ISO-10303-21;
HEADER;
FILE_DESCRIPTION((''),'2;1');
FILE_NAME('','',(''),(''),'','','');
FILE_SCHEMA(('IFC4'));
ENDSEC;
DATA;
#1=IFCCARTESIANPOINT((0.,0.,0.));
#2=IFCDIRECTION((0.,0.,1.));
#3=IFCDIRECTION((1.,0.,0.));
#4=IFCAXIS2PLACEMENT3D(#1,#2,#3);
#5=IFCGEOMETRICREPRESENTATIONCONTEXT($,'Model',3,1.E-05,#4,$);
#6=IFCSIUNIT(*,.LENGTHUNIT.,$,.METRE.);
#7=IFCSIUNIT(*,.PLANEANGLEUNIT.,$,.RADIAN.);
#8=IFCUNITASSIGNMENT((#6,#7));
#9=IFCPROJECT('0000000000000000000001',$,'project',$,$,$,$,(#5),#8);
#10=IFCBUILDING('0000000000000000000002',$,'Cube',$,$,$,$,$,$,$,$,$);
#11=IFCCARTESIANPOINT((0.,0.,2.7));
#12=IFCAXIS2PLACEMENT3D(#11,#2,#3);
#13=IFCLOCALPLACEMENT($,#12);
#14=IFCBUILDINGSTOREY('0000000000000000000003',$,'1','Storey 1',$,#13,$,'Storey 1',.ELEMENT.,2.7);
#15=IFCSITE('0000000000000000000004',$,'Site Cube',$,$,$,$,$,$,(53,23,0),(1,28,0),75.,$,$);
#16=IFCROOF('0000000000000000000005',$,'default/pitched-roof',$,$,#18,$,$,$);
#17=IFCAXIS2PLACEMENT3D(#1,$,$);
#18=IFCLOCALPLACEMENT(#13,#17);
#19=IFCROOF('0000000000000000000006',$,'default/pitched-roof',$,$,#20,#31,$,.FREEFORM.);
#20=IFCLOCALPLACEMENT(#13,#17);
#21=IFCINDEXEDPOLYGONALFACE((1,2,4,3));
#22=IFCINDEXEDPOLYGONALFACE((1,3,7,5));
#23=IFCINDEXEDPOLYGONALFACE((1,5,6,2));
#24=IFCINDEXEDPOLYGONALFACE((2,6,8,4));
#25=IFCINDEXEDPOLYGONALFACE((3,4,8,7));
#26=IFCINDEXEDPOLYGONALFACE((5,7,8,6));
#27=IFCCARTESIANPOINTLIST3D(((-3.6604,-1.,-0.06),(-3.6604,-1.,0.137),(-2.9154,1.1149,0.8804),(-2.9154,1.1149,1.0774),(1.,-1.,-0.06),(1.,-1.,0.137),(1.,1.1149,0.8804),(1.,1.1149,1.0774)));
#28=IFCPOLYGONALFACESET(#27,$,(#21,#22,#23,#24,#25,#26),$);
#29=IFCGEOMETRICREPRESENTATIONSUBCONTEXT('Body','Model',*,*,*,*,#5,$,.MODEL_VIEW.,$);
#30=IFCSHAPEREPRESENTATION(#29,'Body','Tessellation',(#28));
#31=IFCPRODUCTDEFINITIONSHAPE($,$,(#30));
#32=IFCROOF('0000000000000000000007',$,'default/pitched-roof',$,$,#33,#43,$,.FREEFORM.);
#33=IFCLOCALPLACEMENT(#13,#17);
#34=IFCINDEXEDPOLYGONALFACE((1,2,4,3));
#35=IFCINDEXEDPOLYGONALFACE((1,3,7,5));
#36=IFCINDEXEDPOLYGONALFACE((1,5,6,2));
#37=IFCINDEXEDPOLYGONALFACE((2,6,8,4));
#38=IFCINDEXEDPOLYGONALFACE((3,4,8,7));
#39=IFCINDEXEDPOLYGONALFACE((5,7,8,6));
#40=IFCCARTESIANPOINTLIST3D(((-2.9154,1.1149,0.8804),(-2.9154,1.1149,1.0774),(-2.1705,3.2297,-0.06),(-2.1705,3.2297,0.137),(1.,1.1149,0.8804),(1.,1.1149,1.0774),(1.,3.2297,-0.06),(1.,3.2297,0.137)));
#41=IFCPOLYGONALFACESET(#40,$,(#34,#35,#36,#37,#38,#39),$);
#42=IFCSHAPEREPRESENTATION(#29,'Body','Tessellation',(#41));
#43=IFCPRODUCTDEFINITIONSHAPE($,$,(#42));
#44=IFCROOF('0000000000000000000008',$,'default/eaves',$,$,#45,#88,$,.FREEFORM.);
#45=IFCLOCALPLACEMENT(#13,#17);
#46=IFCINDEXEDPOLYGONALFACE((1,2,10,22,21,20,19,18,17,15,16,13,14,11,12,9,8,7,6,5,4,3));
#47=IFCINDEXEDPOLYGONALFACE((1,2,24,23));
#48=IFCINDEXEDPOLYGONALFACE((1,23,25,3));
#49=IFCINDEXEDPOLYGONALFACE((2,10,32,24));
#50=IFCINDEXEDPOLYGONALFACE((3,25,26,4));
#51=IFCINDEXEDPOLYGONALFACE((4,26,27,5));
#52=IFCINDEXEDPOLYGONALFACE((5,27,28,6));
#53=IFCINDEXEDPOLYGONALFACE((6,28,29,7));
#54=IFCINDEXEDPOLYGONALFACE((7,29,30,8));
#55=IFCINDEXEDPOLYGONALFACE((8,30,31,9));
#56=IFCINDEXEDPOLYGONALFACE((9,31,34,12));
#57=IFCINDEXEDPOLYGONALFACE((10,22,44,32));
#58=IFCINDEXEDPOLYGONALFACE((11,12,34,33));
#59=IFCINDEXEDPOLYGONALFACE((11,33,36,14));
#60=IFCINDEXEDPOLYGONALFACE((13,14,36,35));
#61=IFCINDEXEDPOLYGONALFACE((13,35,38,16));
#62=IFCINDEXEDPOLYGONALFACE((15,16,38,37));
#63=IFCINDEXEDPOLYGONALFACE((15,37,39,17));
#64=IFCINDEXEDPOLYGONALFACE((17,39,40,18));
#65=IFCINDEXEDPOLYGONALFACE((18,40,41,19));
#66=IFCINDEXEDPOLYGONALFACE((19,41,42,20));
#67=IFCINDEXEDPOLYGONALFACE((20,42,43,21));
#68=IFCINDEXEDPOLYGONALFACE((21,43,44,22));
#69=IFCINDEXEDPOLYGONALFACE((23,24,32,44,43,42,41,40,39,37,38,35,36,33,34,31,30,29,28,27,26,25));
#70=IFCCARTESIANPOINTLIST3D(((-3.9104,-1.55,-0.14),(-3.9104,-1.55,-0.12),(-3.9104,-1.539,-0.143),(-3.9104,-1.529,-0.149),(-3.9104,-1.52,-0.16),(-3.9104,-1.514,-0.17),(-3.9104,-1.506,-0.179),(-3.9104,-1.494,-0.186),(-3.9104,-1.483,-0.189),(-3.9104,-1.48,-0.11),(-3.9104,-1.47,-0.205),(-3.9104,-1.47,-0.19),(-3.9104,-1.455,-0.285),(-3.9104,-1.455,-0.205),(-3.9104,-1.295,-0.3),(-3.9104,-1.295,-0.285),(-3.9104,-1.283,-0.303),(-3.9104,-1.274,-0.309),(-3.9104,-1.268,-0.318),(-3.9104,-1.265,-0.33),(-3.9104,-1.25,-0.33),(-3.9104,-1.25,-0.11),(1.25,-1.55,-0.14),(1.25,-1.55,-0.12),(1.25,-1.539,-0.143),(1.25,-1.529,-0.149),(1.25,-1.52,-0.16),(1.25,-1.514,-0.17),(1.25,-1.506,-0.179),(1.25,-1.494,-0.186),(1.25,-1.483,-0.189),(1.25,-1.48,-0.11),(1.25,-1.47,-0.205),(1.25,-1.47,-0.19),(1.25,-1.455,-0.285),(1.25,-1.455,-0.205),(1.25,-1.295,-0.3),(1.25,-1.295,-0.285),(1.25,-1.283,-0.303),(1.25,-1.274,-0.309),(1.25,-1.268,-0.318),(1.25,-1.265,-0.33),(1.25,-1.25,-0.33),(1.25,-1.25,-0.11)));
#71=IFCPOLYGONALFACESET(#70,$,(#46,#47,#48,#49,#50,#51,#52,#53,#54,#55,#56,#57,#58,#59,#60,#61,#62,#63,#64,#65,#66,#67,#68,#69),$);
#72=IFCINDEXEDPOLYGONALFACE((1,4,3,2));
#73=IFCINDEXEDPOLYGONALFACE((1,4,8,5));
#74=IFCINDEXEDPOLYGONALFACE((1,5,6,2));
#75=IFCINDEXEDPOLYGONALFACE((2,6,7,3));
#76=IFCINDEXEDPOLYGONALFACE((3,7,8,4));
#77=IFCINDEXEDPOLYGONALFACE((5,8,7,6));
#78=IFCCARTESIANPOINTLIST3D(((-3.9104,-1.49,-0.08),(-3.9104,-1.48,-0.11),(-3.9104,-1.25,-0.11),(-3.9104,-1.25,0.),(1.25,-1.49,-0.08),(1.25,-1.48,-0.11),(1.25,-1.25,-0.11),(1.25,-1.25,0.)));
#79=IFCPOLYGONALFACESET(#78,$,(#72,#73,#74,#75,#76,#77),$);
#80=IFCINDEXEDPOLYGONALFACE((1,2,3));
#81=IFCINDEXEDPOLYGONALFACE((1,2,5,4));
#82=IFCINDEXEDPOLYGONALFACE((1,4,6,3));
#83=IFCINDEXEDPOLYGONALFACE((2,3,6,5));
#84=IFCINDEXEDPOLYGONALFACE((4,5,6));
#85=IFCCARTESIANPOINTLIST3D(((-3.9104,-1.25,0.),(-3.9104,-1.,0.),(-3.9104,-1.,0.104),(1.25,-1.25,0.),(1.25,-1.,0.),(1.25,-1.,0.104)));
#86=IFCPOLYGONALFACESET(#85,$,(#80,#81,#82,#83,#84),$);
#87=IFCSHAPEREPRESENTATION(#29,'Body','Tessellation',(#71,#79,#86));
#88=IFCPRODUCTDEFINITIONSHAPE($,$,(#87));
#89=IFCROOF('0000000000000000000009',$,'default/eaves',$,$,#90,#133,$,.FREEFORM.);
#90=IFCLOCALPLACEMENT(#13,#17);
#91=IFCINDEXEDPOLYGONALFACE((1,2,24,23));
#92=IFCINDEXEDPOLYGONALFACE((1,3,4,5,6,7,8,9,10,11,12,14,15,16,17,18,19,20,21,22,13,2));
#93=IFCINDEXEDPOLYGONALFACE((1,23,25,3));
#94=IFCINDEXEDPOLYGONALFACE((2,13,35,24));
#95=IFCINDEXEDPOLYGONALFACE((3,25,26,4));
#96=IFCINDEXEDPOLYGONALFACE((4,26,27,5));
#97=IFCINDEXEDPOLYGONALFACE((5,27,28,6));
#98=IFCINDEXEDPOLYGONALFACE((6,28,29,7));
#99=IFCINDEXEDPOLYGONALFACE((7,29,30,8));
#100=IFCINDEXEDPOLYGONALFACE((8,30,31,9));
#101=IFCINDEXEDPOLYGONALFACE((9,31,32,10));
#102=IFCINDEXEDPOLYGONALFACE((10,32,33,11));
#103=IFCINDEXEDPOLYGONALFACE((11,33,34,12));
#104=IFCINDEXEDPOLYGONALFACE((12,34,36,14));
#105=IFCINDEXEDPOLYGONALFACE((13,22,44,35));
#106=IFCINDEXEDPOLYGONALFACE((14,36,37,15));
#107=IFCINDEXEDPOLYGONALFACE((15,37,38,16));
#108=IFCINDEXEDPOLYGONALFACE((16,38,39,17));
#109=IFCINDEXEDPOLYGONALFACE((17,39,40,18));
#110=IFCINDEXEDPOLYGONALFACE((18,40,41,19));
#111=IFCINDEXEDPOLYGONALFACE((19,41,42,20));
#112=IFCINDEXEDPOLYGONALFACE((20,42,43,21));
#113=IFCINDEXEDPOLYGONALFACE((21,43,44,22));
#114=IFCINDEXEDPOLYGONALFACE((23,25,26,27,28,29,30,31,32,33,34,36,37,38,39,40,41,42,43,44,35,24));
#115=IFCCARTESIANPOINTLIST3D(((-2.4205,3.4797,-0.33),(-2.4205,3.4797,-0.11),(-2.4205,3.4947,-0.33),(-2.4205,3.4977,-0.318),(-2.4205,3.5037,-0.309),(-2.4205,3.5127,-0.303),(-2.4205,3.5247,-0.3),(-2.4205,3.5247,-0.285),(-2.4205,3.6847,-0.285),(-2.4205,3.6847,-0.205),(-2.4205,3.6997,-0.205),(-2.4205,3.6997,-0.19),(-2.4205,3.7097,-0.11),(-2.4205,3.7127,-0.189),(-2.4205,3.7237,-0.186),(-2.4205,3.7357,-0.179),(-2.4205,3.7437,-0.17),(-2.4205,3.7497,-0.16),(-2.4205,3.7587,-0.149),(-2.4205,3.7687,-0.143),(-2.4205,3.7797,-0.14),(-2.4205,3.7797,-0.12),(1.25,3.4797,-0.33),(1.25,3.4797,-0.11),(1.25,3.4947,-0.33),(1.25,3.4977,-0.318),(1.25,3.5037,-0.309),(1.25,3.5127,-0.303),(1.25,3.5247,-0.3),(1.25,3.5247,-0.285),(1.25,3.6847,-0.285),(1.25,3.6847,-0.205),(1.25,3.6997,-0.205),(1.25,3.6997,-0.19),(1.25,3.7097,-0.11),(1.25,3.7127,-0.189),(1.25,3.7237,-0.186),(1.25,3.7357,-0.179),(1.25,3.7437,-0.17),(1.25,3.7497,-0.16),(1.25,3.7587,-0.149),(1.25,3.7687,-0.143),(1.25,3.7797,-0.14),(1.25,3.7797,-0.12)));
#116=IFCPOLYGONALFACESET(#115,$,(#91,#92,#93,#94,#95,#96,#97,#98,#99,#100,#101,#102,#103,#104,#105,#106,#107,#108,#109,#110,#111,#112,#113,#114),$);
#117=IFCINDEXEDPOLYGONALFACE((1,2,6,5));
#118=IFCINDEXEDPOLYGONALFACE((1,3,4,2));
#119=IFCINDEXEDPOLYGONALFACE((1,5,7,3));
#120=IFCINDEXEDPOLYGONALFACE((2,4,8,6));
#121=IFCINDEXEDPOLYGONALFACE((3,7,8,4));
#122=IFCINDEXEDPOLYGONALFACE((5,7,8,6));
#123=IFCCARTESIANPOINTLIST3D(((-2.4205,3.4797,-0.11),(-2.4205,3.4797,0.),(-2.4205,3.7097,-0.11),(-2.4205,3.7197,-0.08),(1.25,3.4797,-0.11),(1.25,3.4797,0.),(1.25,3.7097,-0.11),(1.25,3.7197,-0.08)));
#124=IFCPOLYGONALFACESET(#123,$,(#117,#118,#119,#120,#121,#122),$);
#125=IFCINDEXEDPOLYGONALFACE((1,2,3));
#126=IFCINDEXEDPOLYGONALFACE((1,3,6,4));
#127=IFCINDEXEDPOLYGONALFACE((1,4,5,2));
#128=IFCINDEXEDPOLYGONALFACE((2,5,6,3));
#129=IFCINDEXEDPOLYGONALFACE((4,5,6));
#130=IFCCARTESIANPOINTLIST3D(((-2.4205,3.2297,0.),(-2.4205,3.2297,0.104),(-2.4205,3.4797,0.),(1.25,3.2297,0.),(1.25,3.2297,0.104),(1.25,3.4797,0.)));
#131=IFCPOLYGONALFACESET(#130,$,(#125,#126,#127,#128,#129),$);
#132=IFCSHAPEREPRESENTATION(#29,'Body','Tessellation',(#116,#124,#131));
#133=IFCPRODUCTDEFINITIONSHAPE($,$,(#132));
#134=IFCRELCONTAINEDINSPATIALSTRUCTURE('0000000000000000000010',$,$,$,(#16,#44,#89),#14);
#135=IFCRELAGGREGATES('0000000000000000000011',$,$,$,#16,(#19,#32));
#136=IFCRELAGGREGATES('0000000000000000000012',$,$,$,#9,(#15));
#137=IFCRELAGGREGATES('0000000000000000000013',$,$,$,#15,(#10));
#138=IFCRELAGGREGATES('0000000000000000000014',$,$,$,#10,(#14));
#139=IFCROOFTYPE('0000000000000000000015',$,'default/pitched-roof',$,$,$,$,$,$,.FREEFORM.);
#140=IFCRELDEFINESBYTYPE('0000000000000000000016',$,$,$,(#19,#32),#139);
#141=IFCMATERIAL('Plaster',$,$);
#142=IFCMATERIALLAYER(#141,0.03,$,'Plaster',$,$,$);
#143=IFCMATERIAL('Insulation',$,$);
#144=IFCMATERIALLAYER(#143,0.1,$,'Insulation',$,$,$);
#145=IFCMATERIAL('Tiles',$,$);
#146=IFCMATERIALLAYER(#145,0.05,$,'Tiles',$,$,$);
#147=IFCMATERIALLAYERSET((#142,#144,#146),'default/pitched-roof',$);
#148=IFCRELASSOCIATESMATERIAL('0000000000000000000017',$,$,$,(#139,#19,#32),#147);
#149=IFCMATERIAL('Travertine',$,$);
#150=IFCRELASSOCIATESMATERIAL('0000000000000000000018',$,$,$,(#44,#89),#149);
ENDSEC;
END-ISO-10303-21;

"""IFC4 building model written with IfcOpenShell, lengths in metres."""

from ifc_helpers import new_model, entity, si_unit, frame, origin, origin_with_axes, place, context, subcontext, project, spatial, polyline, outline, extrude, material, layer, layer_set, layer_usage, type_object, element, aggregate, save


model = new_model("IFC4")

# Units and contexts
model_context = context("Model", 3, precision=1e-05, world=origin_with_axes())
body_context = subcontext(model_context, "Body", "Model", "MODEL_VIEW")
ifc_project = project(units=[si_unit("LENGTHUNIT", "METRE"), si_unit("PLANEANGLEUNIT", "RADIAN")], contexts=[model_context])

# Site, building, storey
site = spatial("IfcSite", under=ifc_project, Name="Site Cube", RefLatitude=(53, 23, 0), RefLongitude=(1, 28, 0), RefElevation=75.0)
building = spatial("IfcBuilding", under=site, Name="Cube")
storey_placement = place(None, frame((0.0, 0.0, 2.7), z_axis=(0.0, 0.0, 1.0), x_axis=(1.0, 0.0, 0.0)))
storey = spatial("IfcBuildingStorey", under=building, at=storey_placement, Name="1", Description="Storey 1", LongName="Storey 1", CompositionType="ELEMENT", Elevation=2.7)

# Roofs
roof_1_placement = place(storey_placement, frame((0.0, 0.0, -2.7), z_axis=(0.0, 0.0, 1.0), x_axis=(1.0, 0.0, 0.0)))
roof_1 = element("IfcRoof", 1, at=roof_1_placement, inside=storey, Name="default/pitched-roof")
ifc_material_1 = material(Name="Plaster")
ifc_layer_1 = layer(ifc_material_1, 0.03, Name="Plaster")
ifc_material_2 = material(Name="Insulation")
ifc_layer_2 = layer(ifc_material_2, 0.1, Name="Insulation")
ifc_material_3 = material(Name="Tiles")
ifc_layer_3 = layer(ifc_material_3, 0.05, Name="Tiles")
ifc_layer_set = layer_set([ifc_layer_1, ifc_layer_2, ifc_layer_3], Name="default/pitched-roof")
ifc_layer_usage_1 = layer_usage(ifc_layer_set, "AXIS3", "POSITIVE", 0.0)
roof_type = type_object("IfcRoofType", Name="default/pitched-roof", PredefinedType="FREEFORM", material=ifc_layer_set)
roof_2_placement = place(roof_1_placement, frame((1.0, 1.1149, 3.5804), z_axis=(0.0, -0.406302, 0.913739), x_axis=(1.0, 0.0, 0.0)))
roof_2 = element("IfcRoof", 2, at=roof_2_placement, type_object=roof_type, material=ifc_layer_usage_1, Name="default/pitched-roof", PredefinedType="FREEFORM", context=body_context, shape_type="SweptSolid", body=[
    extrude(outline(polyline([(0.0, 0.0), (-3.9154, 0.0), (-4.6604, -2.3145), (0.0, -2.3145), (0.0, 0.0)])), origin(), (0.0, 0.406302, 0.913739), 0.197),
])
ifc_layer_usage_2 = layer_usage(ifc_layer_set, "AXIS3", "POSITIVE", 0.0)
roof_3_placement = place(roof_1_placement, frame((-2.1705, 3.2297, 2.64), z_axis=(0.0, 0.406302, 0.913739), x_axis=(-1.0, 0.0, 0.0)))
roof_3 = element("IfcRoof", 3, at=roof_3_placement, type_object=roof_type, material=ifc_layer_usage_2, Name="default/pitched-roof", PredefinedType="FREEFORM", context=body_context, shape_type="SweptSolid", body=[
    extrude(outline(polyline([(0.0, 0.0), (0.7449, 2.3145), (-3.1705, 2.3145), (-3.1705, 0.0), (0.0, 0.0)])), origin(), (0.0, 0.406302, 0.913739), 0.197),
])
aggregate(roof_1, [roof_2, roof_3])
ifc_material_4 = material(Name="Travertine")
roof_4_placement = place(storey_placement, origin_with_axes())
axis2_placement3_d_1 = entity("IfcAxis2Placement3D", entity("IfcCartesianPoint", [0.0, 0.0, 0.0]))
axis2_placement3_d_2 = entity("IfcAxis2Placement3D", entity("IfcCartesianPoint", [0.0, 0.0, 0.0]))
axis2_placement3_d_3 = entity("IfcAxis2Placement3D", entity("IfcCartesianPoint", [0.0, 0.0, 0.0]))
element("IfcRoof", 4, at=roof_4_placement, inside=storey, material=ifc_material_4, Name="default/eaves", PredefinedType="FREEFORM", context=body_context, shape_type="AdvancedSweptSolid", body=[
    entity("IfcSurfaceCurveSweptAreaSolid", entity("IfcDerivedProfileDef", "AREA", None, entity("IfcArbitraryClosedProfileDef", "AREA", None, entity("IfcPolyline", [entity("IfcCartesianPoint", [-0.11, 0.25]), entity("IfcCartesianPoint", [-0.33, 0.25]), entity("IfcCartesianPoint", [-0.33, 0.265]), entity("IfcCartesianPoint", [-0.318, 0.268]), entity("IfcCartesianPoint", [-0.309, 0.274]), entity("IfcCartesianPoint", [-0.303, 0.283]), entity("IfcCartesianPoint", [-0.3, 0.295]), entity("IfcCartesianPoint", [-0.285, 0.295]), entity("IfcCartesianPoint", [-0.285, 0.455]), entity("IfcCartesianPoint", [-0.205, 0.455]), entity("IfcCartesianPoint", [-0.205, 0.47]), entity("IfcCartesianPoint", [-0.19, 0.47]), entity("IfcCartesianPoint", [-0.189, 0.483]), entity("IfcCartesianPoint", [-0.186, 0.494]), entity("IfcCartesianPoint", [-0.179, 0.506]), entity("IfcCartesianPoint", [-0.17, 0.514]), entity("IfcCartesianPoint", [-0.16, 0.52]), entity("IfcCartesianPoint", [-0.149, 0.529]), entity("IfcCartesianPoint", [-0.143, 0.539]), entity("IfcCartesianPoint", [-0.14, 0.55]), entity("IfcCartesianPoint", [-0.12, 0.55]), entity("IfcCartesianPoint", [-0.11, 0.48]), entity("IfcCartesianPoint", [-0.11, 0.25])])), entity("IfcCartesianTransformationOperator2D", None, None, entity("IfcCartesianPoint", [0.0, 0.0]), 1.0)), axis2_placement3_d_1, entity("IfcPolyline", [entity("IfcCartesianPoint", [-3.9104, -1.0]), entity("IfcCartesianPoint", [1.25, -1.0])]), 0.0, 1.0, entity("IfcPlane", axis2_placement3_d_1)),
    entity("IfcSurfaceCurveSweptAreaSolid", entity("IfcDerivedProfileDef", "AREA", None, entity("IfcArbitraryClosedProfileDef", "AREA", None, entity("IfcPolyline", [entity("IfcCartesianPoint", [-0.11, 0.25]), entity("IfcCartesianPoint", [-0.11, 0.48]), entity("IfcCartesianPoint", [-0.08, 0.49]), entity("IfcCartesianPoint", [0.0, 0.25]), entity("IfcCartesianPoint", [-0.11, 0.25])])), entity("IfcCartesianTransformationOperator2D", None, None, entity("IfcCartesianPoint", [0.0, 0.0]), 1.0)), axis2_placement3_d_2, entity("IfcPolyline", [entity("IfcCartesianPoint", [-3.9104, -1.0]), entity("IfcCartesianPoint", [1.25, -1.0])]), 0.0, 1.0, entity("IfcPlane", axis2_placement3_d_2)),
    entity("IfcSurfaceCurveSweptAreaSolid", entity("IfcDerivedProfileDef", "AREA", None, entity("IfcArbitraryClosedProfileDef", "AREA", None, entity("IfcPolyline", [entity("IfcCartesianPoint", [0.0, 0.25]), entity("IfcCartesianPoint", [0.0, 0.0]), entity("IfcCartesianPoint", [0.104, 0.0]), entity("IfcCartesianPoint", [0.0, 0.25])])), entity("IfcCartesianTransformationOperator2D", None, None, entity("IfcCartesianPoint", [0.0, 0.0]), 1.0)), axis2_placement3_d_3, entity("IfcPolyline", [entity("IfcCartesianPoint", [-3.9104, -1.0]), entity("IfcCartesianPoint", [1.25, -1.0])]), 0.0, 1.0, entity("IfcPlane", axis2_placement3_d_3)),
])
roof_5_placement = place(storey_placement, origin_with_axes())
axis2_placement3_d_4 = entity("IfcAxis2Placement3D", entity("IfcCartesianPoint", [0.0, 0.0, 0.0]))
axis2_placement3_d_5 = entity("IfcAxis2Placement3D", entity("IfcCartesianPoint", [0.0, 0.0, 0.0]))
axis2_placement3_d_6 = entity("IfcAxis2Placement3D", entity("IfcCartesianPoint", [0.0, 0.0, 0.0]))
element("IfcRoof", 5, at=roof_5_placement, inside=storey, material=ifc_material_4, Name="default/eaves", PredefinedType="FREEFORM", context=body_context, shape_type="AdvancedSweptSolid", body=[
    entity("IfcSurfaceCurveSweptAreaSolid", entity("IfcDerivedProfileDef", "AREA", None, entity("IfcArbitraryClosedProfileDef", "AREA", None, entity("IfcPolyline", [entity("IfcCartesianPoint", [-0.11, 0.25]), entity("IfcCartesianPoint", [-0.33, 0.25]), entity("IfcCartesianPoint", [-0.33, 0.265]), entity("IfcCartesianPoint", [-0.318, 0.268]), entity("IfcCartesianPoint", [-0.309, 0.274]), entity("IfcCartesianPoint", [-0.303, 0.283]), entity("IfcCartesianPoint", [-0.3, 0.295]), entity("IfcCartesianPoint", [-0.285, 0.295]), entity("IfcCartesianPoint", [-0.285, 0.455]), entity("IfcCartesianPoint", [-0.205, 0.455]), entity("IfcCartesianPoint", [-0.205, 0.47]), entity("IfcCartesianPoint", [-0.19, 0.47]), entity("IfcCartesianPoint", [-0.189, 0.483]), entity("IfcCartesianPoint", [-0.186, 0.494]), entity("IfcCartesianPoint", [-0.179, 0.506]), entity("IfcCartesianPoint", [-0.17, 0.514]), entity("IfcCartesianPoint", [-0.16, 0.52]), entity("IfcCartesianPoint", [-0.149, 0.529]), entity("IfcCartesianPoint", [-0.143, 0.539]), entity("IfcCartesianPoint", [-0.14, 0.55]), entity("IfcCartesianPoint", [-0.12, 0.55]), entity("IfcCartesianPoint", [-0.11, 0.48]), entity("IfcCartesianPoint", [-0.11, 0.25])])), entity("IfcCartesianTransformationOperator2D", None, None, entity("IfcCartesianPoint", [0.0, 0.0]), 1.0)), axis2_placement3_d_4, entity("IfcPolyline", [entity("IfcCartesianPoint", [1.25, 3.2297]), entity("IfcCartesianPoint", [-2.4205, 3.2297])]), 0.0, 1.0, entity("IfcPlane", axis2_placement3_d_4)),
    entity("IfcSurfaceCurveSweptAreaSolid", entity("IfcDerivedProfileDef", "AREA", None, entity("IfcArbitraryClosedProfileDef", "AREA", None, entity("IfcPolyline", [entity("IfcCartesianPoint", [-0.11, 0.25]), entity("IfcCartesianPoint", [-0.11, 0.48]), entity("IfcCartesianPoint", [-0.08, 0.49]), entity("IfcCartesianPoint", [0.0, 0.25]), entity("IfcCartesianPoint", [-0.11, 0.25])])), entity("IfcCartesianTransformationOperator2D", None, None, entity("IfcCartesianPoint", [0.0, 0.0]), 1.0)), axis2_placement3_d_5, entity("IfcPolyline", [entity("IfcCartesianPoint", [1.25, 3.2297]), entity("IfcCartesianPoint", [-2.4205, 3.2297])]), 0.0, 1.0, entity("IfcPlane", axis2_placement3_d_5)),
    entity("IfcSurfaceCurveSweptAreaSolid", entity("IfcDerivedProfileDef", "AREA", None, entity("IfcArbitraryClosedProfileDef", "AREA", None, entity("IfcPolyline", [entity("IfcCartesianPoint", [0.0, 0.25]), entity("IfcCartesianPoint", [0.0, 0.0]), entity("IfcCartesianPoint", [0.104, 0.0]), entity("IfcCartesianPoint", [0.0, 0.25])])), entity("IfcCartesianTransformationOperator2D", None, None, entity("IfcCartesianPoint", [0.0, 0.0]), 1.0)), axis2_placement3_d_6, entity("IfcPolyline", [entity("IfcCartesianPoint", [1.25, 3.2297]), entity("IfcCartesianPoint", [-2.4205, 3.2297])]), 0.0, 1.0, entity("IfcPlane", axis2_placement3_d_6)),
])

save(model, "model.ifc")
